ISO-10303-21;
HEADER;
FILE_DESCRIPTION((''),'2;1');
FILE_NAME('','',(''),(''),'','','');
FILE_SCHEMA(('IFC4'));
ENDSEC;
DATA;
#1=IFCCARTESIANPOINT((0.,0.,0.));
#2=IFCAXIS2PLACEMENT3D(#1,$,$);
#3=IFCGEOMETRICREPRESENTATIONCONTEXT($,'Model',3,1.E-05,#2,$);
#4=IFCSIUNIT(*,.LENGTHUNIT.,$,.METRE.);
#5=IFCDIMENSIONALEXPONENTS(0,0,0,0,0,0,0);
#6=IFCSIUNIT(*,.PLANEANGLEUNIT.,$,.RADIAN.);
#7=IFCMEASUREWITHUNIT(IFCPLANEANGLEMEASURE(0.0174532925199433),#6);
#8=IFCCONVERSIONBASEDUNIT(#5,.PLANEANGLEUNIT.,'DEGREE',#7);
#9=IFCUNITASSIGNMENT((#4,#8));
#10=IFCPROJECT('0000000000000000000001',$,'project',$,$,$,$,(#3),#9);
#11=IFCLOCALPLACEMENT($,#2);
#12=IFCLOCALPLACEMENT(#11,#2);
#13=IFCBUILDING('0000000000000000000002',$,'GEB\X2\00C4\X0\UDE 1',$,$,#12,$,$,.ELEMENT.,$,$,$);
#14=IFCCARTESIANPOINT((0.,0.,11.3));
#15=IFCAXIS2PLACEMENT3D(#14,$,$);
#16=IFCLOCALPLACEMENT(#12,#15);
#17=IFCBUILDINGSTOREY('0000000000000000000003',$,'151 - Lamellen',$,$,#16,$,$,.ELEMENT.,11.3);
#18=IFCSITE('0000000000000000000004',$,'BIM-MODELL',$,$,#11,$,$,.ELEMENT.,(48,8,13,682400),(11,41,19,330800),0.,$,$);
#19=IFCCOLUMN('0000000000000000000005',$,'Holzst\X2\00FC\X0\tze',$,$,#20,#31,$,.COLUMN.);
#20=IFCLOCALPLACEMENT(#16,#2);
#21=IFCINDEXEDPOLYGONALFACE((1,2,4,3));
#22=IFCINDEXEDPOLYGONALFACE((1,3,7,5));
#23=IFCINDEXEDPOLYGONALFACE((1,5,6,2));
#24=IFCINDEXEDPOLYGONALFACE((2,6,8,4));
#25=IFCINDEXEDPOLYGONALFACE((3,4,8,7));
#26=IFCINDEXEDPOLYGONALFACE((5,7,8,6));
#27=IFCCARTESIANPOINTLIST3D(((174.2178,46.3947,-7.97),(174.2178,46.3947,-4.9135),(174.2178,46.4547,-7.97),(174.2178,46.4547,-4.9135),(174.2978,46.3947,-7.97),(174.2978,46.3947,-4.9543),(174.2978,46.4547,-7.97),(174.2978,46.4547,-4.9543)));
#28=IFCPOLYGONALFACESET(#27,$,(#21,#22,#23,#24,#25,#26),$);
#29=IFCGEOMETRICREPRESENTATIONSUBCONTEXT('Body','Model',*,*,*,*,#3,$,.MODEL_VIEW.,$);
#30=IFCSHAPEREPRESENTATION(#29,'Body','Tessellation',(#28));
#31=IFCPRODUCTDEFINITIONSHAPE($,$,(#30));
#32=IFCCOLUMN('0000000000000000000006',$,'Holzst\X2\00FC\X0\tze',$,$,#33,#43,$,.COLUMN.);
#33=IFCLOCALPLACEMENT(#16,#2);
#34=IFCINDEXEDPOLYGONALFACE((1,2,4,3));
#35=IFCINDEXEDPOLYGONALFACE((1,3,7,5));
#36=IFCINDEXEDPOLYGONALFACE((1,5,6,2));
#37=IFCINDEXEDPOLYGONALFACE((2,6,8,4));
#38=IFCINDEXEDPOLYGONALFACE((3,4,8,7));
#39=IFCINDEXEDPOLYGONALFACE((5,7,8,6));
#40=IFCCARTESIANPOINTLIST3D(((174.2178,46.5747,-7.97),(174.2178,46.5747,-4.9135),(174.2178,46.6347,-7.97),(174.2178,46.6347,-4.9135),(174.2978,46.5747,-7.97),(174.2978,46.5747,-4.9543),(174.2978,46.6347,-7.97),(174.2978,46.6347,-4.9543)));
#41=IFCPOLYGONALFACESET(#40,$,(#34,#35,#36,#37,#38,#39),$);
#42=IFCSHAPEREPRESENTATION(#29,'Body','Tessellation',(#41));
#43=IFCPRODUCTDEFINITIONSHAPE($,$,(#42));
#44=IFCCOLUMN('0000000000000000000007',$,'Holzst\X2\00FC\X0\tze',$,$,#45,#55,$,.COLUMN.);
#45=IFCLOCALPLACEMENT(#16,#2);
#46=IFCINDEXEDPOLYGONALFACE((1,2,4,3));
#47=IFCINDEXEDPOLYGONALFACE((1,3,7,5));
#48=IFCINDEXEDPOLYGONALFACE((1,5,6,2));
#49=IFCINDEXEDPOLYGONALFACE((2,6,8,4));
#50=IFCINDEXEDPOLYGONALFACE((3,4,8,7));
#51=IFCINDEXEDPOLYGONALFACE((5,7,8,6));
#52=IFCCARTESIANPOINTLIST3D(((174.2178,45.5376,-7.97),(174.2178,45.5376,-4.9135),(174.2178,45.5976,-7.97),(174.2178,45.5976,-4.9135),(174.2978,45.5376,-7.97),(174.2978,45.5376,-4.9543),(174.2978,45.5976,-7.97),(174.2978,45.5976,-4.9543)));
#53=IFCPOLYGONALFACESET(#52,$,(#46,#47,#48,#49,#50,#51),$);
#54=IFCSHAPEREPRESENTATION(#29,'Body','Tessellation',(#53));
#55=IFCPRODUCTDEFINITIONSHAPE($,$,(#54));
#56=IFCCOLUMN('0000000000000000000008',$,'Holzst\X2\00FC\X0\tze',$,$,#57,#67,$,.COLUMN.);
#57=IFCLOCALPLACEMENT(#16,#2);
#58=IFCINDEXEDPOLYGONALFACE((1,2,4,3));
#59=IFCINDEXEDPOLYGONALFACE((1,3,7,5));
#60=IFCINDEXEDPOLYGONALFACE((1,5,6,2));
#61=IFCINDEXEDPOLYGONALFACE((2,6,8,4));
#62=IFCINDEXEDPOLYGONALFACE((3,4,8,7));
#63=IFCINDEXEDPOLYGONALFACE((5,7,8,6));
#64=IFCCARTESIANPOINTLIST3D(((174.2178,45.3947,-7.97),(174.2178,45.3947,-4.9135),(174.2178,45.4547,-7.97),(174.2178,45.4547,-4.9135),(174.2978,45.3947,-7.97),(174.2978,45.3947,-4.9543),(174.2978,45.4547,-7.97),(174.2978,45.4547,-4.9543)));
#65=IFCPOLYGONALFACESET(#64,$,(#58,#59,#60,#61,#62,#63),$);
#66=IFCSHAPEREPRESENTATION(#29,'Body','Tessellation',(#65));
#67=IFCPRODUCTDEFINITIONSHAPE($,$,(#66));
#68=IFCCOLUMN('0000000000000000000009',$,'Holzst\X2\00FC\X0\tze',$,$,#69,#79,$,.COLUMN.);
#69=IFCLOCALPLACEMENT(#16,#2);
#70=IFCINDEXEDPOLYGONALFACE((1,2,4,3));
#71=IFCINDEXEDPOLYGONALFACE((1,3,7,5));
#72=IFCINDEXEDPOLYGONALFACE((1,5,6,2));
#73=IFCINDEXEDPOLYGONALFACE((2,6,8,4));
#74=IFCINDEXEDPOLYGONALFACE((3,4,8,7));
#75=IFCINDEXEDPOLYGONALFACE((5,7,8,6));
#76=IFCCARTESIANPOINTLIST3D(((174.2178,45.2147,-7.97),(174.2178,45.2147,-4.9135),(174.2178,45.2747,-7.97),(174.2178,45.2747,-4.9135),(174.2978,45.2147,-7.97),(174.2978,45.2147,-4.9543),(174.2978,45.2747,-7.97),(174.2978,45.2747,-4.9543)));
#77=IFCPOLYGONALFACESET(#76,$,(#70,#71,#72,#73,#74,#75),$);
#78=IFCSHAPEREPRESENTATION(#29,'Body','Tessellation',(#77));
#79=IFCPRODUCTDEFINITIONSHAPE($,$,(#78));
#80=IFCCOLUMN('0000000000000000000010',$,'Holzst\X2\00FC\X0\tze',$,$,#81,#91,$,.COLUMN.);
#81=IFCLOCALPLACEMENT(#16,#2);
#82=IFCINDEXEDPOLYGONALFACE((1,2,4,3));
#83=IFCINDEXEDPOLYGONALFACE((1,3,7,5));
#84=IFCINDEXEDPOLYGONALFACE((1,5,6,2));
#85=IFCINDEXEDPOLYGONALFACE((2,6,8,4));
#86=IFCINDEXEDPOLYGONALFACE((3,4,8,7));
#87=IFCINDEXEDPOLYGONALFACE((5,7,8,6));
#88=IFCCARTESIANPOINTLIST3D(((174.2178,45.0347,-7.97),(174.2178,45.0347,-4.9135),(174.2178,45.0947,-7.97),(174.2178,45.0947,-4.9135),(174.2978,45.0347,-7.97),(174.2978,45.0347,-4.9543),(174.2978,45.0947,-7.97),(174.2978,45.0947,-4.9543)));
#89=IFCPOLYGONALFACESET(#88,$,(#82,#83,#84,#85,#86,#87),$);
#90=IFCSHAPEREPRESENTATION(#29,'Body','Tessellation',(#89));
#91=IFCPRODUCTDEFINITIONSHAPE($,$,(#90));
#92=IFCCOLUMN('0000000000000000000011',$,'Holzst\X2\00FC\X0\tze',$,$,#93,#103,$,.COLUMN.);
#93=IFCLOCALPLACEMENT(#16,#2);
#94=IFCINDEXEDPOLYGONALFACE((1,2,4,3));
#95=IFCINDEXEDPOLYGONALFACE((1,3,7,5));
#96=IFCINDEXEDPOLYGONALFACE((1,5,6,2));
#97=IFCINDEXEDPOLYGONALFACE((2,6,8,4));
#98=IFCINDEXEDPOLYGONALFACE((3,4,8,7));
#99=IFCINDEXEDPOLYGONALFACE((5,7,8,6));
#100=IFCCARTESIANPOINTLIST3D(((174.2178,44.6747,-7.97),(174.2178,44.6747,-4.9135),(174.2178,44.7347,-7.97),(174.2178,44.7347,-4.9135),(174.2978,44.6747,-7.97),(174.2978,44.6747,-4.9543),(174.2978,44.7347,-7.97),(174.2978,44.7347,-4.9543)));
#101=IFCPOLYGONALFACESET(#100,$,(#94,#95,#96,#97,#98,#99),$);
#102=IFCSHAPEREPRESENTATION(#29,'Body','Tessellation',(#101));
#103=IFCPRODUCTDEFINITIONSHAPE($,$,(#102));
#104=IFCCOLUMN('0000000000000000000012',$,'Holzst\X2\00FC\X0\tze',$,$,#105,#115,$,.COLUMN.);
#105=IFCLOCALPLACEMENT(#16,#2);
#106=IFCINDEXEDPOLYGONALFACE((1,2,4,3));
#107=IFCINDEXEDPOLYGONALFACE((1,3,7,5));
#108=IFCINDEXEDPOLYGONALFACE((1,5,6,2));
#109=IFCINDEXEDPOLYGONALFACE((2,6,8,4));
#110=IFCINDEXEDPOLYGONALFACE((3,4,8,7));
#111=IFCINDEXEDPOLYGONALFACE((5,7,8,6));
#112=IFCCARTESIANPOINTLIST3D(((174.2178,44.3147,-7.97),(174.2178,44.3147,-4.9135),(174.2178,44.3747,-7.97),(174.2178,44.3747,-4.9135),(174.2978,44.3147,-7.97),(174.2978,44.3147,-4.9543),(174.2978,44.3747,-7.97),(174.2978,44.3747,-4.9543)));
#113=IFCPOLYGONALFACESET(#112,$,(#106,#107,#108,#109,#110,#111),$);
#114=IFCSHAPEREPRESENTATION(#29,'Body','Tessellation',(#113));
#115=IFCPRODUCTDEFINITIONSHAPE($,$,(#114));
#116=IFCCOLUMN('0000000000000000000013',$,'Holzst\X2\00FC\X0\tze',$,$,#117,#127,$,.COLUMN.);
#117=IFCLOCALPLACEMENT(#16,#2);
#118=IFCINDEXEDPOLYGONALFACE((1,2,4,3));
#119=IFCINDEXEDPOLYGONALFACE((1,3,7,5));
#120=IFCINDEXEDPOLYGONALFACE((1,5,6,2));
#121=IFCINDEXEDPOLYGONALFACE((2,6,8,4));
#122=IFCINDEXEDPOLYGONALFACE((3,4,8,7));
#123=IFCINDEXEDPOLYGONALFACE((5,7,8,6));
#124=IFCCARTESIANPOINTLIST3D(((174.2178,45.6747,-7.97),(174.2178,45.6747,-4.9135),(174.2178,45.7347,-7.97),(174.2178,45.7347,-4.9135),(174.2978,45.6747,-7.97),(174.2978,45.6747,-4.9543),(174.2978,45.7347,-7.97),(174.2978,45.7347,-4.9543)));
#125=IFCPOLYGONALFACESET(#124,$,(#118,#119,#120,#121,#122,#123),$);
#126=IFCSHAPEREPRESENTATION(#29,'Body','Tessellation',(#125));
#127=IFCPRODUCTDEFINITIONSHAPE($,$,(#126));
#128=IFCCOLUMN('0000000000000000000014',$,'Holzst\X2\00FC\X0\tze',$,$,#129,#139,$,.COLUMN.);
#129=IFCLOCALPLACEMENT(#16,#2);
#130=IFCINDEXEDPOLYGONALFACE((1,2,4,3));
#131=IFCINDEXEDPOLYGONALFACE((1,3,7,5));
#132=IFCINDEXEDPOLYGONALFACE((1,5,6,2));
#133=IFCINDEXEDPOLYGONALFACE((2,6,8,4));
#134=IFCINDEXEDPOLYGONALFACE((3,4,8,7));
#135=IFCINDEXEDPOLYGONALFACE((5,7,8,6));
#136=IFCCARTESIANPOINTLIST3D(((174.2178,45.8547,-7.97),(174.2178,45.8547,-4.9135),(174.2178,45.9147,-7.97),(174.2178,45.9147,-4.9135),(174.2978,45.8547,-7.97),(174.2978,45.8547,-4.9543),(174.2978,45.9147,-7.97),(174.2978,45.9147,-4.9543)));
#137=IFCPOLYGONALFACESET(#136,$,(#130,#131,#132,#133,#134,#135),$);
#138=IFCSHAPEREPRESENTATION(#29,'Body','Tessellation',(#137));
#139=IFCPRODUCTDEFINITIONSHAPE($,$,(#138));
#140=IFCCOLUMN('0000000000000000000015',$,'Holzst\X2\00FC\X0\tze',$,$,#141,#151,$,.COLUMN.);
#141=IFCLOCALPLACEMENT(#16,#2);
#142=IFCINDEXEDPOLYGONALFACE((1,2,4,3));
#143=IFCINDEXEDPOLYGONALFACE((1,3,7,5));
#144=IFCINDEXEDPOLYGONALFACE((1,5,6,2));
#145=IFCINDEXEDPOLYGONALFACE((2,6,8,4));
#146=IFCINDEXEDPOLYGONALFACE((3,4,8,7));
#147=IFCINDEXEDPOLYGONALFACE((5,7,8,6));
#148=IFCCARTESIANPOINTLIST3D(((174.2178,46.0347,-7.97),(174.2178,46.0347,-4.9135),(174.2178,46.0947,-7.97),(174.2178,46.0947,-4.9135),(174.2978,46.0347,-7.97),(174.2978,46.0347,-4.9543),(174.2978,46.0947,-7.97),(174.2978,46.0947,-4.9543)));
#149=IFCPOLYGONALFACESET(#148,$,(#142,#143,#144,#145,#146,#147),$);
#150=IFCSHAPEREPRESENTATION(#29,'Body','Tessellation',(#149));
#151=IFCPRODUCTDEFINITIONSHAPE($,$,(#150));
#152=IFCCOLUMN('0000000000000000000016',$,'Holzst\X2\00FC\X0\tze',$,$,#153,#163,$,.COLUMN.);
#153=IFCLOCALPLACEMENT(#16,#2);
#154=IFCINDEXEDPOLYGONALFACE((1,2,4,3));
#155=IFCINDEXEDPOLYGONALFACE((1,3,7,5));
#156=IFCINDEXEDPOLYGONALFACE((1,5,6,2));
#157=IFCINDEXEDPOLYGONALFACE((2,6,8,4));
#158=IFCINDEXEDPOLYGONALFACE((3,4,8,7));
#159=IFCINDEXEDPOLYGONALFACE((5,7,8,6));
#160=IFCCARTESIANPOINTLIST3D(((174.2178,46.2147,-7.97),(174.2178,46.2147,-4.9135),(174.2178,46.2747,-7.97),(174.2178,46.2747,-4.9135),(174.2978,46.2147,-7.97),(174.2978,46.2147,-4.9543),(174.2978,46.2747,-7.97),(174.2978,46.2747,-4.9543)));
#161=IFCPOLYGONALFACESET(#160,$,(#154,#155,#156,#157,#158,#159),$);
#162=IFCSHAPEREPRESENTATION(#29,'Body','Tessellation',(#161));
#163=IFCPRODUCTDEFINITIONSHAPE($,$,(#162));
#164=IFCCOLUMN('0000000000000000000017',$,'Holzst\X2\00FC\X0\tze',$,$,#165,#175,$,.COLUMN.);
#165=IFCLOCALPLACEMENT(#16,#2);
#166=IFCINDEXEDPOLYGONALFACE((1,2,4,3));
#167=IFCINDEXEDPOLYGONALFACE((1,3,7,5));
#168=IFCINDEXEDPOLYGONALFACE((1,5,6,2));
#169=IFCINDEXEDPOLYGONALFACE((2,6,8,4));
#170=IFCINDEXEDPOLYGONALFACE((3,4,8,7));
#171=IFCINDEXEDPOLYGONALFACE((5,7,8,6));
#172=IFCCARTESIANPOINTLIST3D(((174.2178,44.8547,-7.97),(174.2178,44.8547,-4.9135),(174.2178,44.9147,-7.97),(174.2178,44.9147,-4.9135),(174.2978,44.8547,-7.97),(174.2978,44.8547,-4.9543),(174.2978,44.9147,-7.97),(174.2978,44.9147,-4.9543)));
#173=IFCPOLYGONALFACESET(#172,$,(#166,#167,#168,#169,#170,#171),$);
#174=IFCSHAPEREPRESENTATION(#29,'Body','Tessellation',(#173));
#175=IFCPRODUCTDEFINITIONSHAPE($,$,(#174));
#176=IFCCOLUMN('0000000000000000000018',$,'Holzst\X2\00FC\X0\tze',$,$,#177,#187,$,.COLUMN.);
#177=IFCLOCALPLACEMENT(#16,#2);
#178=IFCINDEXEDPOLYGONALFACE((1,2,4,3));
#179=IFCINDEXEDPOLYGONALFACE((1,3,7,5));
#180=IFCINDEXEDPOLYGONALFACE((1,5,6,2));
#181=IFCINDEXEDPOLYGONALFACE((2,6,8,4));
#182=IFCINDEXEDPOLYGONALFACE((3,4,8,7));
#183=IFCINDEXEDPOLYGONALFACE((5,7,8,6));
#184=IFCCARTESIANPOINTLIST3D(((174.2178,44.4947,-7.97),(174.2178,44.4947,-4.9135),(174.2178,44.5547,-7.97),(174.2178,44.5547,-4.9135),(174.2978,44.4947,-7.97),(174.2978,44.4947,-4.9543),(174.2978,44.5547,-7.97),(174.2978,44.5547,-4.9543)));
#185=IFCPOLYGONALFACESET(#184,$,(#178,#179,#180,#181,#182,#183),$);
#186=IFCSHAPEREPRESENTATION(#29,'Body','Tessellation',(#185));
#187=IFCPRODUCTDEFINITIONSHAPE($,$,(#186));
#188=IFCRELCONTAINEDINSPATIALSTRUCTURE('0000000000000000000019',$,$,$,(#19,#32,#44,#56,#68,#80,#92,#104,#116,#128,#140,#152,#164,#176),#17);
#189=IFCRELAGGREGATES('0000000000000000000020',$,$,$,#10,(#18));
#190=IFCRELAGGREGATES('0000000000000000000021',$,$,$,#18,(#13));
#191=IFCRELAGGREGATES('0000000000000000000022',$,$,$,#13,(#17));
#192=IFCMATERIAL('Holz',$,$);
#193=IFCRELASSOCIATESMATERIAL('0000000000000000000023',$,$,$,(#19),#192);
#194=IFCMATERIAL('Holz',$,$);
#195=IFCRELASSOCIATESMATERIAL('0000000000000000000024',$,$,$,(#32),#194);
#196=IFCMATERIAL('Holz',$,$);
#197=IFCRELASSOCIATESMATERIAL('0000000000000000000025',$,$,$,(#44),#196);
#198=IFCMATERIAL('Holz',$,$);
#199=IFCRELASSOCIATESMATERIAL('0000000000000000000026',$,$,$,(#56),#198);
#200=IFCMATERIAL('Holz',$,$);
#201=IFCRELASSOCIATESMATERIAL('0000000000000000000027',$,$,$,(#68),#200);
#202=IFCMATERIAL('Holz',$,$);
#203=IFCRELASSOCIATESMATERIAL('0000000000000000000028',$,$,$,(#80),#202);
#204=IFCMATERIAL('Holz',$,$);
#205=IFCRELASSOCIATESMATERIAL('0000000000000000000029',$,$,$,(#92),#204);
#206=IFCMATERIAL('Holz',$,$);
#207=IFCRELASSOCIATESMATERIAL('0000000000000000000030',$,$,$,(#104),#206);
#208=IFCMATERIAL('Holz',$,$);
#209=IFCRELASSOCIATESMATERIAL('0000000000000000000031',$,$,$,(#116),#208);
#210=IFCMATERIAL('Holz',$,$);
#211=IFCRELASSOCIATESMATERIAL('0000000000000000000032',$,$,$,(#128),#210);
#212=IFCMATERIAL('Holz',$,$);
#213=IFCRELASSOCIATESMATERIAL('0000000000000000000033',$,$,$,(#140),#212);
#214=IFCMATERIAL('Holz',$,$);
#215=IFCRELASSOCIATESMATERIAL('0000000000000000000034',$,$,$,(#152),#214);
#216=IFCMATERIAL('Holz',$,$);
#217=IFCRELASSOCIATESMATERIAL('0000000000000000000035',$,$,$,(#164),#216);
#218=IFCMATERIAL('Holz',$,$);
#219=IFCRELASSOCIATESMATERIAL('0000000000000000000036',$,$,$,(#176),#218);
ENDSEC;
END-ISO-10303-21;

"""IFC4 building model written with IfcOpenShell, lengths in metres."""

from ifc_helpers import new_model, entity, si_unit, converted_unit, frame, frame_2d, origin, origin_with_axes, place, context, subcontext, project, spatial, rectangle, extrude, clip, halfspace, material, element, save


model = new_model("IFC4")

# Units and contexts
model_context = context("Model", 3, precision=1e-05, world=origin())
body_context = subcontext(model_context, "Body", "Model", "MODEL_VIEW")
ifc_project = project(units=[si_unit("LENGTHUNIT", "METRE"), converted_unit("PLANEANGLEUNIT", "DEGREE", entity("IfcPlaneAngleMeasure", 0.0174532925199433), si_unit("PLANEANGLEUNIT", "RADIAN"), dimensions=[0, 0, 0, 0, 0, 0, 0])], contexts=[model_context])

# Site, building, storey
site_placement = place(None, origin())
site = spatial("IfcSite", under=ifc_project, at=site_placement, Name="BIM-MODELL", CompositionType="ELEMENT", RefLatitude=(48, 8, 13, 682400), RefLongitude=(11, 41, 19, 330800), RefElevation=0.0)
building_placement = place(site_placement, origin())
building = spatial("IfcBuilding", under=site, at=building_placement, Name="GEBÄUDE 1", CompositionType="ELEMENT")
storey_placement = place(building_placement, frame((0.0, 0.0, 11.3)))
storey = spatial("IfcBuildingStorey", under=building, at=storey_placement, Name="151 - Lamellen", CompositionType="ELEMENT", Elevation=11.3)

# Columns
ifc_material_1 = material(Name="Holz")
column_1_placement = place(storey_placement, frame((174.2978, 46.3947, -7.97)))
element("IfcColumn", 1, at=column_1_placement, inside=storey, material=ifc_material_1, Name="Holzstütze", PredefinedType="COLUMN", context=body_context, shape_type="Clipping", body=[
    clip(extrude(rectangle(XDim=0.06, YDim=0.08, at=frame_2d((-0.04, 0.03), x_axis=(0.0, 1.0))), origin_with_axes(), (0.0, 0.0, 1.0), 3.0565), halfspace(frame((-0.04, 0.03, 3.0361), z_axis=(-0.45399, 0.0, -0.891007), x_axis=(0.891007, 0.0, -0.45399)), True)),
])
ifc_material_2 = material(Name="Holz")
column_2_placement = place(storey_placement, frame((174.2978, 46.5747, -7.97)))
element("IfcColumn", 2, at=column_2_placement, inside=storey, material=ifc_material_2, Name="Holzstütze", PredefinedType="COLUMN", context=body_context, shape_type="Clipping", body=[
    clip(extrude(rectangle(XDim=0.06, YDim=0.08, at=frame_2d((-0.04, 0.03), x_axis=(0.0, 1.0))), origin_with_axes(), (0.0, 0.0, 1.0), 3.0565), halfspace(frame((-0.04, 0.03, 3.0361), z_axis=(-0.45399, 0.0, -0.891007), x_axis=(0.891007, 0.0, -0.45399)), True)),
])
ifc_material_3 = material(Name="Holz")
column_3_placement = place(storey_placement, frame((174.2978, 45.5376, -7.97)))
element("IfcColumn", 3, at=column_3_placement, inside=storey, material=ifc_material_3, Name="Holzstütze", PredefinedType="COLUMN", context=body_context, shape_type="Clipping", body=[
    clip(extrude(rectangle(XDim=0.06, YDim=0.08, at=frame_2d((-0.04, 0.03), x_axis=(0.0, 1.0))), origin_with_axes(), (0.0, 0.0, 1.0), 3.0565), halfspace(frame((-0.04, 0.03, 3.0361), z_axis=(-0.45399, 0.0, -0.891007), x_axis=(0.891007, 0.0, -0.45399)), True)),
])
ifc_material_4 = material(Name="Holz")
column_4_placement = place(storey_placement, frame((174.2978, 45.3947, -7.97)))
element("IfcColumn", 4, at=column_4_placement, inside=storey, material=ifc_material_4, Name="Holzstütze", PredefinedType="COLUMN", context=body_context, shape_type="Clipping", body=[
    clip(extrude(rectangle(XDim=0.06, YDim=0.08, at=frame_2d((-0.04, 0.03), x_axis=(0.0, 1.0))), origin_with_axes(), (0.0, 0.0, 1.0), 3.0565), halfspace(frame((-0.04, 0.03, 3.0361), z_axis=(-0.45399, 0.0, -0.891007), x_axis=(0.891007, 0.0, -0.45399)), True)),
])
ifc_material_5 = material(Name="Holz")
column_5_placement = place(storey_placement, frame((174.2978, 45.2147, -7.97)))
element("IfcColumn", 5, at=column_5_placement, inside=storey, material=ifc_material_5, Name="Holzstütze", PredefinedType="COLUMN", context=body_context, shape_type="Clipping", body=[
    clip(extrude(rectangle(XDim=0.06, YDim=0.08, at=frame_2d((-0.04, 0.03), x_axis=(0.0, 1.0))), origin_with_axes(), (0.0, 0.0, 1.0), 3.0565), halfspace(frame((-0.04, 0.03, 3.0361), z_axis=(-0.45399, 0.0, -0.891007), x_axis=(0.891007, 0.0, -0.45399)), True)),
])
ifc_material_6 = material(Name="Holz")
column_6_placement = place(storey_placement, frame((174.2978, 45.0347, -7.97)))
element("IfcColumn", 6, at=column_6_placement, inside=storey, material=ifc_material_6, Name="Holzstütze", PredefinedType="COLUMN", context=body_context, shape_type="Clipping", body=[
    clip(extrude(rectangle(XDim=0.06, YDim=0.08, at=frame_2d((-0.04, 0.03), x_axis=(0.0, 1.0))), origin_with_axes(), (0.0, 0.0, 1.0), 3.0565), halfspace(frame((-0.04, 0.03, 3.0361), z_axis=(-0.45399, 0.0, -0.891007), x_axis=(0.891007, 0.0, -0.45399)), True)),
])
ifc_material_7 = material(Name="Holz")
column_7_placement = place(storey_placement, frame((174.2978, 44.6747, -7.97)))
element("IfcColumn", 7, at=column_7_placement, inside=storey, material=ifc_material_7, Name="Holzstütze", PredefinedType="COLUMN", context=body_context, shape_type="Clipping", body=[
    clip(extrude(rectangle(XDim=0.06, YDim=0.08, at=frame_2d((-0.04, 0.03), x_axis=(0.0, 1.0))), origin_with_axes(), (0.0, 0.0, 1.0), 3.0565), halfspace(frame((-0.04, 0.03, 3.0361), z_axis=(-0.45399, 0.0, -0.891007), x_axis=(0.891007, 0.0, -0.45399)), True)),
])
ifc_material_8 = material(Name="Holz")
column_8_placement = place(storey_placement, frame((174.2978, 44.3147, -7.97)))
element("IfcColumn", 8, at=column_8_placement, inside=storey, material=ifc_material_8, Name="Holzstütze", PredefinedType="COLUMN", context=body_context, shape_type="Clipping", body=[
    clip(extrude(rectangle(XDim=0.06, YDim=0.08, at=frame_2d((-0.04, 0.03), x_axis=(0.0, 1.0))), origin_with_axes(), (0.0, 0.0, 1.0), 3.0565), halfspace(frame((-0.04, 0.03, 3.0361), z_axis=(-0.45399, 0.0, -0.891007), x_axis=(0.891007, 0.0, -0.45399)), True)),
])
ifc_material_9 = material(Name="Holz")
column_9_placement = place(storey_placement, frame((174.2978, 45.6747, -7.97)))
element("IfcColumn", 9, at=column_9_placement, inside=storey, material=ifc_material_9, Name="Holzstütze", PredefinedType="COLUMN", context=body_context, shape_type="Clipping", body=[
    clip(extrude(rectangle(XDim=0.06, YDim=0.08, at=frame_2d((-0.04, 0.03), x_axis=(0.0, 1.0))), origin_with_axes(), (0.0, 0.0, 1.0), 3.0565), halfspace(frame((-0.04, 0.03, 3.0361), z_axis=(-0.45399, 0.0, -0.891007), x_axis=(0.891007, 0.0, -0.45399)), True)),
])
ifc_material_10 = material(Name="Holz")
column_10_placement = place(storey_placement, frame((174.2978, 45.8547, -7.97)))
element("IfcColumn", 10, at=column_10_placement, inside=storey, material=ifc_material_10, Name="Holzstütze", PredefinedType="COLUMN", context=body_context, shape_type="Clipping", body=[
    clip(extrude(rectangle(XDim=0.06, YDim=0.08, at=frame_2d((-0.04, 0.03), x_axis=(0.0, 1.0))), origin_with_axes(), (0.0, 0.0, 1.0), 3.0565), halfspace(frame((-0.04, 0.03, 3.0361), z_axis=(-0.45399, 0.0, -0.891007), x_axis=(0.891007, 0.0, -0.45399)), True)),
])
ifc_material_11 = material(Name="Holz")
column_11_placement = place(storey_placement, frame((174.2978, 46.0347, -7.97)))
element("IfcColumn", 11, at=column_11_placement, inside=storey, material=ifc_material_11, Name="Holzstütze", PredefinedType="COLUMN", context=body_context, shape_type="Clipping", body=[
    clip(extrude(rectangle(XDim=0.06, YDim=0.08, at=frame_2d((-0.04, 0.03), x_axis=(0.0, 1.0))), origin_with_axes(), (0.0, 0.0, 1.0), 3.0565), halfspace(frame((-0.04, 0.03, 3.0361), z_axis=(-0.45399, 0.0, -0.891007), x_axis=(0.891007, 0.0, -0.45399)), True)),
])
ifc_material_12 = material(Name="Holz")
column_12_placement = place(storey_placement, frame((174.2978, 46.2147, -7.97)))
element("IfcColumn", 12, at=column_12_placement, inside=storey, material=ifc_material_12, Name="Holzstütze", PredefinedType="COLUMN", context=body_context, shape_type="Clipping", body=[
    clip(extrude(rectangle(XDim=0.06, YDim=0.08, at=frame_2d((-0.04, 0.03), x_axis=(0.0, 1.0))), origin_with_axes(), (0.0, 0.0, 1.0), 3.0565), halfspace(frame((-0.04, 0.03, 3.0361), z_axis=(-0.45399, 0.0, -0.891007), x_axis=(0.891007, 0.0, -0.45399)), True)),
])
ifc_material_13 = material(Name="Holz")
column_13_placement = place(storey_placement, frame((174.2978, 44.8547, -7.97)))
element("IfcColumn", 13, at=column_13_placement, inside=storey, material=ifc_material_13, Name="Holzstütze", PredefinedType="COLUMN", context=body_context, shape_type="Clipping", body=[
    clip(extrude(rectangle(XDim=0.06, YDim=0.08, at=frame_2d((-0.04, 0.03), x_axis=(0.0, 1.0))), origin_with_axes(), (0.0, 0.0, 1.0), 3.0565), halfspace(frame((-0.04, 0.03, 3.0361), z_axis=(-0.45399, 0.0, -0.891007), x_axis=(0.891007, 0.0, -0.45399)), True)),
])
ifc_material_14 = material(Name="Holz")
column_14_placement = place(storey_placement, frame((174.2978, 44.4947, -7.97)))
element("IfcColumn", 14, at=column_14_placement, inside=storey, material=ifc_material_14, Name="Holzstütze", PredefinedType="COLUMN", context=body_context, shape_type="Clipping", body=[
    clip(extrude(rectangle(XDim=0.06, YDim=0.08, at=frame_2d((-0.04, 0.03), x_axis=(0.0, 1.0))), origin_with_axes(), (0.0, 0.0, 1.0), 3.0565), halfspace(frame((-0.04, 0.03, 3.0361), z_axis=(-0.45399, 0.0, -0.891007), x_axis=(0.891007, 0.0, -0.45399)), True)),
])

save(model, "model.ifc")
